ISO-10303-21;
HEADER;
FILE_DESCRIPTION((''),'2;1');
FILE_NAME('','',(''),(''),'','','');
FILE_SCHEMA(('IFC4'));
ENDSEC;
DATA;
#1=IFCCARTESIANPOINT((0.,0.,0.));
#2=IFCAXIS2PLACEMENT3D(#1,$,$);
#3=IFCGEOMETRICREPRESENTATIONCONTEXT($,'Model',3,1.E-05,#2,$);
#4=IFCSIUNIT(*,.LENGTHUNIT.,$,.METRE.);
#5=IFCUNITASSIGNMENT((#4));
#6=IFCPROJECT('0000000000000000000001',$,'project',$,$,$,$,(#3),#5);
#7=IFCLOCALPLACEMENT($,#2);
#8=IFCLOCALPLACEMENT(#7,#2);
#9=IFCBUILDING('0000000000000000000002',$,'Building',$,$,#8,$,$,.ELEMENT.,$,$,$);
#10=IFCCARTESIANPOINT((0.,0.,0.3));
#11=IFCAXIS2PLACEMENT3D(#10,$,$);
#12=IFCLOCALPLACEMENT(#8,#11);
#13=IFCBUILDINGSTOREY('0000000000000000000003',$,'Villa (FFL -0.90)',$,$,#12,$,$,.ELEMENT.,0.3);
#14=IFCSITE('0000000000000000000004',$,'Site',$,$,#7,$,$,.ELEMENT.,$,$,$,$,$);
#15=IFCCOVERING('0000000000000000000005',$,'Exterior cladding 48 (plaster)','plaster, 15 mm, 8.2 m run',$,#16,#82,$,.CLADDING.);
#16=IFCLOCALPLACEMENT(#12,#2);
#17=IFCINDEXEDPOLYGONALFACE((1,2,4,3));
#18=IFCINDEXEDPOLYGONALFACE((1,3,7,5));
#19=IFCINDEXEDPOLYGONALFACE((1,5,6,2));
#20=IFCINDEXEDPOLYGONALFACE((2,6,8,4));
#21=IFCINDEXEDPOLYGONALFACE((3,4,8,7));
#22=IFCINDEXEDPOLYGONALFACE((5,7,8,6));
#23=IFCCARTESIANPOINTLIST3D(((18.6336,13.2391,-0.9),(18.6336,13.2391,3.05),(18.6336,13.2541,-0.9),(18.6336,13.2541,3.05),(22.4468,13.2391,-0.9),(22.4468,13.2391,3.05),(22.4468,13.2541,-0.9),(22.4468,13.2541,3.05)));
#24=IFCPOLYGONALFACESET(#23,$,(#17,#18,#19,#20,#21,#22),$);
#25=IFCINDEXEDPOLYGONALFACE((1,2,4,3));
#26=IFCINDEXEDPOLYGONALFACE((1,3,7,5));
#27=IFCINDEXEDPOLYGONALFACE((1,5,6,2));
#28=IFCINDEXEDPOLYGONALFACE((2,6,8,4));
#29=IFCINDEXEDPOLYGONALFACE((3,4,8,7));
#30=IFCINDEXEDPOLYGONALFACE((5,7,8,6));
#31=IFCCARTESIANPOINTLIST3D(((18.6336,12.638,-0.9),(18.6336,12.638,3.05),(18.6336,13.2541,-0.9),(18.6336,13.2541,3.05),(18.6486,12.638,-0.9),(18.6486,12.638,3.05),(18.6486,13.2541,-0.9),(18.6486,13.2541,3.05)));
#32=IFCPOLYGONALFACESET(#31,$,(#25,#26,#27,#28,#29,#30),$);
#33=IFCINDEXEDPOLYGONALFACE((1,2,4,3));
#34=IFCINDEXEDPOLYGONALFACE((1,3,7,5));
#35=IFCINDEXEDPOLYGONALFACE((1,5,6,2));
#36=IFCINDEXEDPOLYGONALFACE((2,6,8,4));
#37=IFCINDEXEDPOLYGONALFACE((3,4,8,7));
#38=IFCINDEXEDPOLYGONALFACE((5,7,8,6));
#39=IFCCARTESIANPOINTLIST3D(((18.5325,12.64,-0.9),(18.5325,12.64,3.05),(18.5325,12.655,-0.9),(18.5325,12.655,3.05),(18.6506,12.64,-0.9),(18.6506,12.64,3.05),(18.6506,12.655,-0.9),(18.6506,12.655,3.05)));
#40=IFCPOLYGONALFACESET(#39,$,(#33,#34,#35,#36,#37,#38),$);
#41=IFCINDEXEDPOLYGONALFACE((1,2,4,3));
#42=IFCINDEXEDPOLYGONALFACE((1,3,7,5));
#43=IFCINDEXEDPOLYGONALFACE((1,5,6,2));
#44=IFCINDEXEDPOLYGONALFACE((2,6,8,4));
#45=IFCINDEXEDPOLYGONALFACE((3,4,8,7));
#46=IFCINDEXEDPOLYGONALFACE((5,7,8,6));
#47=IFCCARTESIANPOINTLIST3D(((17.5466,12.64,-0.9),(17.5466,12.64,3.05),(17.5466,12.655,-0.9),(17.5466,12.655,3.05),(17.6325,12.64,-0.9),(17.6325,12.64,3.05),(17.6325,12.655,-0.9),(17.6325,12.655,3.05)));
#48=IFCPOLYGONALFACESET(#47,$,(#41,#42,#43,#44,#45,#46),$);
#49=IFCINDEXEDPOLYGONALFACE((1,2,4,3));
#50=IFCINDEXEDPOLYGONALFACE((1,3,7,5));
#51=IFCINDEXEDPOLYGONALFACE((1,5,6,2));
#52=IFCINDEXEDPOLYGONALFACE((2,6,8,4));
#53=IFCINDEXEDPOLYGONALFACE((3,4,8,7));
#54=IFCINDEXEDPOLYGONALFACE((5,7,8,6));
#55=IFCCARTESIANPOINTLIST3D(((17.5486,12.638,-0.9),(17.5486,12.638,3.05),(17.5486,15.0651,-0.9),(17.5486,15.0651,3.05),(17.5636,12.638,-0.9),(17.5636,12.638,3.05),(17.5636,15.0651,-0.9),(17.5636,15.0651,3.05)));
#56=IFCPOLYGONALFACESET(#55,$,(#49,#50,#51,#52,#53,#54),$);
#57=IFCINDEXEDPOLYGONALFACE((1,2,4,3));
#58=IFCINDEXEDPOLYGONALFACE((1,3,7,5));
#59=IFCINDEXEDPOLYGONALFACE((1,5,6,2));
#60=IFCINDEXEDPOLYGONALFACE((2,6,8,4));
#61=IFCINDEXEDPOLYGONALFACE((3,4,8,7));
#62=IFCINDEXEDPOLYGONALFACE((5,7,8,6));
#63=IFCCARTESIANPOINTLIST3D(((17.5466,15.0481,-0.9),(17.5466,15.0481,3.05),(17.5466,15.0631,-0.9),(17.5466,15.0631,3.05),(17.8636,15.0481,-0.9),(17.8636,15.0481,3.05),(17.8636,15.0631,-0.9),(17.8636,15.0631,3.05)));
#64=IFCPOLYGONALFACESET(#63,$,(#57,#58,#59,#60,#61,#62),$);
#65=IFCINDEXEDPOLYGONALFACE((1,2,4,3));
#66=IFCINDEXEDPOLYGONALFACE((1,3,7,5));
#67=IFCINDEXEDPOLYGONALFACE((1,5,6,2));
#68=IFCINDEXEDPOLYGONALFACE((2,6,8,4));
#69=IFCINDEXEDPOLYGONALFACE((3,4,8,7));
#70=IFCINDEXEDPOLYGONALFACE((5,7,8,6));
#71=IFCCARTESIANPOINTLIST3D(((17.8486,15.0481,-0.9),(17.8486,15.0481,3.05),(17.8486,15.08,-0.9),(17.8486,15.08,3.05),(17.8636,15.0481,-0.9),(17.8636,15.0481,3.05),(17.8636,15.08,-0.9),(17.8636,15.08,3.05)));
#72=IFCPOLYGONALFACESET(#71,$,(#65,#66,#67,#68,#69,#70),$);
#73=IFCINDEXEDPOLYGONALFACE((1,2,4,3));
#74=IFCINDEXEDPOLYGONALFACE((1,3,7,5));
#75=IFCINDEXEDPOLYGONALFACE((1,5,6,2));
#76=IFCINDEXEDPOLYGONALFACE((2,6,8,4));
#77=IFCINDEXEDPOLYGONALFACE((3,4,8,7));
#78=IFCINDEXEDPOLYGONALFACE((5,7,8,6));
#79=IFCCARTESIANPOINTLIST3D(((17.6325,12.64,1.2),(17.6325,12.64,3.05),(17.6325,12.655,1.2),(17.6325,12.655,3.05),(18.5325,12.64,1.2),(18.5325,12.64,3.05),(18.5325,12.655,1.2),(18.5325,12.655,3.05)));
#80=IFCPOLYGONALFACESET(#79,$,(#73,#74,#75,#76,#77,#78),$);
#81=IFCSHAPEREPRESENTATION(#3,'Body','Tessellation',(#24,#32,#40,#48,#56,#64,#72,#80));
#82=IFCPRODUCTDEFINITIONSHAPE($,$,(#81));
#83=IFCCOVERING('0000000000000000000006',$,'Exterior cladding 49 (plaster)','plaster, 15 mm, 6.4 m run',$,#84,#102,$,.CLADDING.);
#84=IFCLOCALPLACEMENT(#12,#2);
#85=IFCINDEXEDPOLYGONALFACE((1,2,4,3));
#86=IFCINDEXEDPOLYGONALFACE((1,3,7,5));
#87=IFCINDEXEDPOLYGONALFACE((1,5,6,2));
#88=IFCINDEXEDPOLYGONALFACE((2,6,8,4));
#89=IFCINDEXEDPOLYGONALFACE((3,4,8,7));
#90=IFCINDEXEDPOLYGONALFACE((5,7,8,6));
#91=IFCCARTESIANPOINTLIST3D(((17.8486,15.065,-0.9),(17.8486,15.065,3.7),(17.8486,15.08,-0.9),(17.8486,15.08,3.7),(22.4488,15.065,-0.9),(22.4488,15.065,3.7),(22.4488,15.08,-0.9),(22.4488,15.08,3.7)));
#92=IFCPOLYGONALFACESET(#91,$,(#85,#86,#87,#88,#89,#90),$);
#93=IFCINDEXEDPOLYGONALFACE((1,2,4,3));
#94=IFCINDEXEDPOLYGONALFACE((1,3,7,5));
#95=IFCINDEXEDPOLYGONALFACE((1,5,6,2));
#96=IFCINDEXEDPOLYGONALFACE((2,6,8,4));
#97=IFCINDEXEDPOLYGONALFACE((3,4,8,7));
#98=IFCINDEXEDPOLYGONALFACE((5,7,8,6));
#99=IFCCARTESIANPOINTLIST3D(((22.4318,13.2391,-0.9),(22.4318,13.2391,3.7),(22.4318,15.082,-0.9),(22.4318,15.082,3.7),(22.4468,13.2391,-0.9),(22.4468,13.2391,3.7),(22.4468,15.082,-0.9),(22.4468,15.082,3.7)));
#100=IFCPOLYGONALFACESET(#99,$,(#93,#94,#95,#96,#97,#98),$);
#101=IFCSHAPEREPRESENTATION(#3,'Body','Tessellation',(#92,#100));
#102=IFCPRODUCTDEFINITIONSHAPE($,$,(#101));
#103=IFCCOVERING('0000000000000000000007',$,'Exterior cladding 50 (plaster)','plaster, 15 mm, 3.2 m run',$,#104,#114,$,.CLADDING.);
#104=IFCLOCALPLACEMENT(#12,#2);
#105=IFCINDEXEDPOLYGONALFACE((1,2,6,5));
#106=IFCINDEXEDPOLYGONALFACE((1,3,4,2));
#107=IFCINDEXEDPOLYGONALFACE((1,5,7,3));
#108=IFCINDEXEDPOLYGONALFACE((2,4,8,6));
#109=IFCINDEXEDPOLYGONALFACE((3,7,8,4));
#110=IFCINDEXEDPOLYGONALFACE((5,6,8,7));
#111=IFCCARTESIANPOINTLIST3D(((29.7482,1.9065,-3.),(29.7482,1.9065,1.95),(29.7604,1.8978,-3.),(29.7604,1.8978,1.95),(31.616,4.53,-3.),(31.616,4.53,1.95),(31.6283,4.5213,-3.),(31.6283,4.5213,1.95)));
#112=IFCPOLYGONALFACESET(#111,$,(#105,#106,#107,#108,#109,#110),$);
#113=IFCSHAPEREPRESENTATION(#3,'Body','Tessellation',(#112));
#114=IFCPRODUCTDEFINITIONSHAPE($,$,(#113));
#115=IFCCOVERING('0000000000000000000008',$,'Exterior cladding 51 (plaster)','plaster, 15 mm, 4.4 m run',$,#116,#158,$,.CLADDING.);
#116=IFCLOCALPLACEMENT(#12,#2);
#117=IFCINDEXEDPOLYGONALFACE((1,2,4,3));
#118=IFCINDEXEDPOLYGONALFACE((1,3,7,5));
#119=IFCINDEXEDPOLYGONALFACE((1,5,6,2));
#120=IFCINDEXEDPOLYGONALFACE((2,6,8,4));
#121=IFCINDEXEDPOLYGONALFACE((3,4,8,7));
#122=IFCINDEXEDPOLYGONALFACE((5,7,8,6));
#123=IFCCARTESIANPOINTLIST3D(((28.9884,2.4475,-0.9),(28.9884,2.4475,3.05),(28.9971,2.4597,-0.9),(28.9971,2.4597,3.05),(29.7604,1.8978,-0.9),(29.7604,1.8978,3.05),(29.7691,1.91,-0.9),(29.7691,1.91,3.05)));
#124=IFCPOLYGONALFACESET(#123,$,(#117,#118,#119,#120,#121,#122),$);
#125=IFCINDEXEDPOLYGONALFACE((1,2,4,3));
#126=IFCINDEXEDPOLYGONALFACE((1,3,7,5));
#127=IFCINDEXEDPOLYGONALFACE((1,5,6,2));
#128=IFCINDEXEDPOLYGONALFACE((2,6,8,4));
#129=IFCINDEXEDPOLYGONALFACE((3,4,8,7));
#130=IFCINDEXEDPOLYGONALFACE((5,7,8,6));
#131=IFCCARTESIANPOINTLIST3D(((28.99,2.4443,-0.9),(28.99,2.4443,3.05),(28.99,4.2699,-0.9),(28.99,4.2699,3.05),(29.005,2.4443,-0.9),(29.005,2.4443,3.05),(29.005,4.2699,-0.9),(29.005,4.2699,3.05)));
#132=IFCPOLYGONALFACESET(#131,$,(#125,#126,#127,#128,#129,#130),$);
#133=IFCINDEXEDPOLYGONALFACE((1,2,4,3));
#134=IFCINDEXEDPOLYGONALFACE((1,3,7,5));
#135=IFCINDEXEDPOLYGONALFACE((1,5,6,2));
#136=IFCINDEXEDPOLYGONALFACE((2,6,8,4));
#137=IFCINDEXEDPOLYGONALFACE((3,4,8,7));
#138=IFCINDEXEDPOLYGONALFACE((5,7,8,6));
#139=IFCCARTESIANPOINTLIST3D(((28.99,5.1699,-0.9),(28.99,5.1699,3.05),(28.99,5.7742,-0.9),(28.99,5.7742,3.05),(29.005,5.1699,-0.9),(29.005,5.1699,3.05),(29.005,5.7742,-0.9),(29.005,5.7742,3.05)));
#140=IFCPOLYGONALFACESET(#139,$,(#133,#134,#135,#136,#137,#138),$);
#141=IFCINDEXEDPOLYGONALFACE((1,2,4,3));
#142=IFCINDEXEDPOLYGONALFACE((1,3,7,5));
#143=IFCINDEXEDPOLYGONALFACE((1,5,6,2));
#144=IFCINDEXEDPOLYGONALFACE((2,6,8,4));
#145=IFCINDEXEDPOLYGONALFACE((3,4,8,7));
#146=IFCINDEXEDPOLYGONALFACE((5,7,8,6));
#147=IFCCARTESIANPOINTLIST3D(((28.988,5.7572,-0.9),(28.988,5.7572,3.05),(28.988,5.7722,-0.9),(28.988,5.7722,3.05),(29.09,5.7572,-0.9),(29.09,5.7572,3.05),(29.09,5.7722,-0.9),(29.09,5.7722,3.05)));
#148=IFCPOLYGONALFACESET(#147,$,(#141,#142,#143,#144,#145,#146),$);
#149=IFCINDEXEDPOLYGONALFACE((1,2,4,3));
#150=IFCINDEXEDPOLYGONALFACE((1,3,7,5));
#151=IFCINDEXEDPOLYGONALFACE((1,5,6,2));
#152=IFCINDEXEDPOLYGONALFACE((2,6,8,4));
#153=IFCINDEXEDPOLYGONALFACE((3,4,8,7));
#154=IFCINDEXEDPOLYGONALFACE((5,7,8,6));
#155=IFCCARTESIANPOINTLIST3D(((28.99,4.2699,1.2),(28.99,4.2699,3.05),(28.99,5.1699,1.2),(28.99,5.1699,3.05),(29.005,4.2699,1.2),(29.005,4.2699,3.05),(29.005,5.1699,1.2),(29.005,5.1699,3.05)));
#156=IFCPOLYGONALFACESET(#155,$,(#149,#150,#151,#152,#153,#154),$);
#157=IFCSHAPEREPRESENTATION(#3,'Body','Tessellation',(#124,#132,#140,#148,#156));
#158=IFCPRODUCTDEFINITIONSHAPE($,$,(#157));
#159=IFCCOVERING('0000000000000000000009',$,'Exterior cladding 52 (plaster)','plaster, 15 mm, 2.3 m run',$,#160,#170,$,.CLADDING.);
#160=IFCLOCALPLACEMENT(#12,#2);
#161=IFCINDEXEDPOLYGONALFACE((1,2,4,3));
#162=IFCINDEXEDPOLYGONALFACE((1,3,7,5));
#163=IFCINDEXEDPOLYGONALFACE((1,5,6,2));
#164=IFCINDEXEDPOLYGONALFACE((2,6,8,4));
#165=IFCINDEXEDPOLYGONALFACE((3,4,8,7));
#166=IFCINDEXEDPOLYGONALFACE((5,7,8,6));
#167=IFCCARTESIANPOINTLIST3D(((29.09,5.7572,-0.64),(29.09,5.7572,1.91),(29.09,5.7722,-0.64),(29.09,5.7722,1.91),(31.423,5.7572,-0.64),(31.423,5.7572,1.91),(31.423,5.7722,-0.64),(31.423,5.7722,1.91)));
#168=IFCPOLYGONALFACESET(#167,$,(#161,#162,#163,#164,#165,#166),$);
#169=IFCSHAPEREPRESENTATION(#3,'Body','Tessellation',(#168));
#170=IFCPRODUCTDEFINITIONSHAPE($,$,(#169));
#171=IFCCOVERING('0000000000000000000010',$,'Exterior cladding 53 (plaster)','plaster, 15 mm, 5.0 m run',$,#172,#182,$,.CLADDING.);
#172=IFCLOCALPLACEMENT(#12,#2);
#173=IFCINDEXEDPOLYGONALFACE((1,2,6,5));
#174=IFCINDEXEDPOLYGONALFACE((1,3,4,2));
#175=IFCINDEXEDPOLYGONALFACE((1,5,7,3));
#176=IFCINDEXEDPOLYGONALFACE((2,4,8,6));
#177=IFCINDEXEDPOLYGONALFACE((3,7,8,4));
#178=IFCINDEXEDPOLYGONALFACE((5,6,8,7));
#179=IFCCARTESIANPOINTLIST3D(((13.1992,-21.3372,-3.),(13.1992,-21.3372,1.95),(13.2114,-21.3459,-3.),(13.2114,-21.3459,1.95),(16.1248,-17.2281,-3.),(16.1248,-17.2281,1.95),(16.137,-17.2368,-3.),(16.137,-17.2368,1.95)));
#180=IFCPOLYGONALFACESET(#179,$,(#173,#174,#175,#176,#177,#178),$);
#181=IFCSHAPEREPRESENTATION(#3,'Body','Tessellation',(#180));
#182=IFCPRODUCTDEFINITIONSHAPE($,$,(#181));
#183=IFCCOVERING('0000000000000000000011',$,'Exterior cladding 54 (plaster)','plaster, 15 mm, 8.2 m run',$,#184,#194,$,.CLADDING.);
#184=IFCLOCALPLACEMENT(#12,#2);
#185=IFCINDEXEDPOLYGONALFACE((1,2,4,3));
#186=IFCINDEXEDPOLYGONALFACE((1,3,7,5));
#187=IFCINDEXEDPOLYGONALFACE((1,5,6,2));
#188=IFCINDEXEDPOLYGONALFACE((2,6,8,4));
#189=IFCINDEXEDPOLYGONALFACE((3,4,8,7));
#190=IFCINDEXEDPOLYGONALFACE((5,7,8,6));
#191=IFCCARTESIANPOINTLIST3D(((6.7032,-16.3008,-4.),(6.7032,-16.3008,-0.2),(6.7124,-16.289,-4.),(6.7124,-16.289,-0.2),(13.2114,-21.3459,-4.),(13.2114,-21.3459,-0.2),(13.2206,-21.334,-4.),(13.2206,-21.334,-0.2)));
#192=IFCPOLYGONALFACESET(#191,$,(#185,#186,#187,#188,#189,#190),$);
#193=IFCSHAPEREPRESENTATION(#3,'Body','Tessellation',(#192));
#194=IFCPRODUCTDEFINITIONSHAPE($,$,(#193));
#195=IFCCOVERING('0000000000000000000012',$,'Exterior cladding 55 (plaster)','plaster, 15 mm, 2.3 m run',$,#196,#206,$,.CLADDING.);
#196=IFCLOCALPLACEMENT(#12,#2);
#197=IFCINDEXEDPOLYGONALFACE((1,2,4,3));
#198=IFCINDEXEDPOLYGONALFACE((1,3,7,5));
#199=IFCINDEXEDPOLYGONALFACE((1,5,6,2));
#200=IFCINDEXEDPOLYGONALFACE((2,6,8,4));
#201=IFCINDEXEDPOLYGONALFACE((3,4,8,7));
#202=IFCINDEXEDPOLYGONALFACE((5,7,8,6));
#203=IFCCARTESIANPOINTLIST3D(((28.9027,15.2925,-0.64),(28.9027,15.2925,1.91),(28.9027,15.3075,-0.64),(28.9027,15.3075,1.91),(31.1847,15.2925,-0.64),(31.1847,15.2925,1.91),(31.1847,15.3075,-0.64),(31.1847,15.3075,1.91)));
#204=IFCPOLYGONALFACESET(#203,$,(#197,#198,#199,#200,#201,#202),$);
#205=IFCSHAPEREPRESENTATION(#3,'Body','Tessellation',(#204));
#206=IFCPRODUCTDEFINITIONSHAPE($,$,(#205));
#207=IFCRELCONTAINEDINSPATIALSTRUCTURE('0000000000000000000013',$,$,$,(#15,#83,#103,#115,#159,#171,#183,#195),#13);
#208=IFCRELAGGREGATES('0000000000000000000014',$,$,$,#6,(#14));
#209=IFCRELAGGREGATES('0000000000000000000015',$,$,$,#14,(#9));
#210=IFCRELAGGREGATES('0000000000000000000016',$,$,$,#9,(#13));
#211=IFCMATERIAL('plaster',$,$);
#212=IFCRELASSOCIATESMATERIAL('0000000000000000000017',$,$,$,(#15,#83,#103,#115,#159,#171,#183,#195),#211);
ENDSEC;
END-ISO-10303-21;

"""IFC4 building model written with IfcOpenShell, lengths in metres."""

from ifc_helpers import new_model, si_unit, frame, origin, origin_with_axes, place, context, project, spatial, polyline, outline, extrude, material, element, save


model = new_model("IFC4")

# Units and contexts
model_context = context("Model", 3, precision=1e-05, world=origin())
ifc_project = project(units=[si_unit("LENGTHUNIT", "METRE")], contexts=[model_context])

# Site, building, storey
site_placement = place(None, origin())
site = spatial("IfcSite", under=ifc_project, at=site_placement, Name="Site", CompositionType="ELEMENT")
building_placement = place(site_placement, origin())
building = spatial("IfcBuilding", under=site, at=building_placement, Name="Building", CompositionType="ELEMENT")
storey_placement = place(building_placement, frame((0.0, 0.0, 0.3)))
storey = spatial("IfcBuildingStorey", under=building, at=storey_placement, Name="Villa (FFL -0.90)", CompositionType="ELEMENT", Elevation=0.3)

# Coverings
ifc_material = material(Name="plaster")
covering_1_placement = place(storey_placement, origin_with_axes())
element("IfcCovering", 1, at=covering_1_placement, inside=storey, material=ifc_material, Name="Exterior cladding 48 (plaster)", Description="plaster, 15 mm, 8.2 m run", PredefinedType="CLADDING", context=model_context, shape_type="SweptSolid", body=[
    extrude(outline(polyline([(22.4468, 13.2541), (18.6336, 13.2541), (18.6336, 13.2391), (22.4468, 13.2391), (22.4468, 13.2541)])), frame((0.0, 0.0, -0.9)), (0.0, 0.0, 1.0), 3.95),
    extrude(outline(polyline([(18.6336, 13.2541), (18.6336, 12.638), (18.6486, 12.638), (18.6486, 13.2541), (18.6336, 13.2541)])), frame((0.0, 0.0, -0.9)), (0.0, 0.0, 1.0), 3.95),
    extrude(outline(polyline([(18.6506, 12.655), (18.5325, 12.655), (18.5325, 12.64), (18.6506, 12.64), (18.6506, 12.655)])), frame((0.0, 0.0, -0.9)), (0.0, 0.0, 1.0), 3.95),
    extrude(outline(polyline([(17.6325, 12.655), (17.5466, 12.655), (17.5466, 12.64), (17.6325, 12.64), (17.6325, 12.655)])), frame((0.0, 0.0, -0.9)), (0.0, 0.0, 1.0), 3.95),
    extrude(outline(polyline([(17.5636, 12.638), (17.5636, 15.0651), (17.5486, 15.0651), (17.5486, 12.638), (17.5636, 12.638)])), frame((0.0, 0.0, -0.9)), (0.0, 0.0, 1.0), 3.95),
    extrude(outline(polyline([(17.5466, 15.0481), (17.8636, 15.0481), (17.8636, 15.0631), (17.5466, 15.0631), (17.5466, 15.0481)])), frame((0.0, 0.0, -0.9)), (0.0, 0.0, 1.0), 3.95),
    extrude(outline(polyline([(17.8636, 15.0481), (17.8636, 15.08), (17.8486, 15.08), (17.8486, 15.0481), (17.8636, 15.0481)])), frame((0.0, 0.0, -0.9)), (0.0, 0.0, 1.0), 3.95),
    extrude(outline(polyline([(18.5325, 12.655), (17.6325, 12.655), (17.6325, 12.64), (18.5325, 12.64), (18.5325, 12.655)])), frame((0.0, 0.0, 1.2)), (0.0, 0.0, 1.0), 1.85),
])
covering_2_placement = place(storey_placement, origin_with_axes())
element("IfcCovering", 2, at=covering_2_placement, inside=storey, material=ifc_material, Name="Exterior cladding 49 (plaster)", Description="plaster, 15 mm, 6.4 m run", PredefinedType="CLADDING", context=model_context, shape_type="SweptSolid", body=[
    extrude(outline(polyline([(17.8486, 15.065), (22.4488, 15.065), (22.4488, 15.08), (17.8486, 15.08), (17.8486, 15.065)])), frame((0.0, 0.0, -0.9)), (0.0, 0.0, 1.0), 4.6),
    extrude(outline(polyline([(22.4318, 15.082), (22.4318, 13.2391), (22.4468, 13.2391), (22.4468, 15.082), (22.4318, 15.082)])), frame((0.0, 0.0, -0.9)), (0.0, 0.0, 1.0), 4.6),
])
covering_3_placement = place(storey_placement, origin_with_axes())
element("IfcCovering", 3, at=covering_3_placement, inside=storey, material=ifc_material, Name="Exterior cladding 50 (plaster)", Description="plaster, 15 mm, 3.2 m run", PredefinedType="CLADDING", context=model_context, shape_type="SweptSolid", body=[
    extrude(outline(polyline([(31.616, 4.53), (29.7482, 1.9065), (29.7604, 1.8978), (31.6283, 4.5213), (31.616, 4.53)])), frame((0.0, 0.0, -3.0)), (0.0, 0.0, 1.0), 4.95),
])
covering_4_placement = place(storey_placement, origin_with_axes())
element("IfcCovering", 4, at=covering_4_placement, inside=storey, material=ifc_material, Name="Exterior cladding 51 (plaster)", Description="plaster, 15 mm, 4.4 m run", PredefinedType="CLADDING", context=model_context, shape_type="SweptSolid", body=[
    extrude(outline(polyline([(29.7691, 1.91), (28.9971, 2.4597), (28.9884, 2.4475), (29.7604, 1.8978), (29.7691, 1.91)])), frame((0.0, 0.0, -0.9)), (0.0, 0.0, 1.0), 3.95),
    extrude(outline(polyline([(29.005, 2.4443), (29.005, 4.2699), (28.99, 4.2699), (28.99, 2.4443), (29.005, 2.4443)])), frame((0.0, 0.0, -0.9)), (0.0, 0.0, 1.0), 3.95),
    extrude(outline(polyline([(29.005, 5.1699), (29.005, 5.7741), (28.99, 5.7741), (28.99, 5.1699), (29.005, 5.1699)])), frame((0.0, 0.0, -0.9)), (0.0, 0.0, 1.0), 3.95),
    extrude(outline(polyline([(28.988, 5.7572), (29.09, 5.7572), (29.09, 5.7721), (28.988, 5.7721), (28.988, 5.7572)])), frame((0.0, 0.0, -0.9)), (0.0, 0.0, 1.0), 3.95),
    extrude(outline(polyline([(29.005, 4.2699), (29.005, 5.1699), (28.99, 5.1699), (28.99, 4.2699), (29.005, 4.2699)])), frame((0.0, 0.0, 1.2)), (0.0, 0.0, 1.0), 1.85),
])
covering_5_placement = place(storey_placement, origin_with_axes())
element("IfcCovering", 5, at=covering_5_placement, inside=storey, material=ifc_material, Name="Exterior cladding 52 (plaster)", Description="plaster, 15 mm, 2.3 m run", PredefinedType="CLADDING", context=model_context, shape_type="SweptSolid", body=[
    extrude(outline(polyline([(29.09, 5.7572), (31.423, 5.7572), (31.423, 5.7721), (29.09, 5.7721), (29.09, 5.7572)])), frame((0.0, 0.0, -0.64)), (0.0, 0.0, 1.0), 2.55),
])
covering_6_placement = place(storey_placement, origin_with_axes())
element("IfcCovering", 6, at=covering_6_placement, inside=storey, material=ifc_material, Name="Exterior cladding 53 (plaster)", Description="plaster, 15 mm, 5.0 m run", PredefinedType="CLADDING", context=model_context, shape_type="SweptSolid", body=[
    extrude(outline(polyline([(16.1248, -17.2281), (13.1992, -21.3372), (13.2114, -21.3459), (16.137, -17.2368), (16.1248, -17.2281)])), frame((0.0, 0.0, -3.0)), (0.0, 0.0, 1.0), 4.95),
])
covering_7_placement = place(storey_placement, origin_with_axes())
element("IfcCovering", 7, at=covering_7_placement, inside=storey, material=ifc_material, Name="Exterior cladding 54 (plaster)", Description="plaster, 15 mm, 8.2 m run", PredefinedType="CLADDING", context=model_context, shape_type="SweptSolid", body=[
    extrude(outline(polyline([(13.2206, -21.334), (6.7124, -16.289), (6.7032, -16.3009), (13.2114, -21.3459), (13.2206, -21.334)])), frame((0.0, 0.0, -4.0)), (0.0, 0.0, 1.0), 3.8),
])
covering_8_placement = place(storey_placement, origin_with_axes())
element("IfcCovering", 8, at=covering_8_placement, inside=storey, material=ifc_material, Name="Exterior cladding 55 (plaster)", Description="plaster, 15 mm, 2.3 m run", PredefinedType="CLADDING", context=model_context, shape_type="SweptSolid", body=[
    extrude(outline(polyline([(31.1847, 15.3075), (28.9027, 15.3075), (28.9027, 15.2925), (31.1847, 15.2925), (31.1847, 15.3075)])), frame((0.0, 0.0, -0.64)), (0.0, 0.0, 1.0), 2.55),
])

save(model, "model.ifc")
